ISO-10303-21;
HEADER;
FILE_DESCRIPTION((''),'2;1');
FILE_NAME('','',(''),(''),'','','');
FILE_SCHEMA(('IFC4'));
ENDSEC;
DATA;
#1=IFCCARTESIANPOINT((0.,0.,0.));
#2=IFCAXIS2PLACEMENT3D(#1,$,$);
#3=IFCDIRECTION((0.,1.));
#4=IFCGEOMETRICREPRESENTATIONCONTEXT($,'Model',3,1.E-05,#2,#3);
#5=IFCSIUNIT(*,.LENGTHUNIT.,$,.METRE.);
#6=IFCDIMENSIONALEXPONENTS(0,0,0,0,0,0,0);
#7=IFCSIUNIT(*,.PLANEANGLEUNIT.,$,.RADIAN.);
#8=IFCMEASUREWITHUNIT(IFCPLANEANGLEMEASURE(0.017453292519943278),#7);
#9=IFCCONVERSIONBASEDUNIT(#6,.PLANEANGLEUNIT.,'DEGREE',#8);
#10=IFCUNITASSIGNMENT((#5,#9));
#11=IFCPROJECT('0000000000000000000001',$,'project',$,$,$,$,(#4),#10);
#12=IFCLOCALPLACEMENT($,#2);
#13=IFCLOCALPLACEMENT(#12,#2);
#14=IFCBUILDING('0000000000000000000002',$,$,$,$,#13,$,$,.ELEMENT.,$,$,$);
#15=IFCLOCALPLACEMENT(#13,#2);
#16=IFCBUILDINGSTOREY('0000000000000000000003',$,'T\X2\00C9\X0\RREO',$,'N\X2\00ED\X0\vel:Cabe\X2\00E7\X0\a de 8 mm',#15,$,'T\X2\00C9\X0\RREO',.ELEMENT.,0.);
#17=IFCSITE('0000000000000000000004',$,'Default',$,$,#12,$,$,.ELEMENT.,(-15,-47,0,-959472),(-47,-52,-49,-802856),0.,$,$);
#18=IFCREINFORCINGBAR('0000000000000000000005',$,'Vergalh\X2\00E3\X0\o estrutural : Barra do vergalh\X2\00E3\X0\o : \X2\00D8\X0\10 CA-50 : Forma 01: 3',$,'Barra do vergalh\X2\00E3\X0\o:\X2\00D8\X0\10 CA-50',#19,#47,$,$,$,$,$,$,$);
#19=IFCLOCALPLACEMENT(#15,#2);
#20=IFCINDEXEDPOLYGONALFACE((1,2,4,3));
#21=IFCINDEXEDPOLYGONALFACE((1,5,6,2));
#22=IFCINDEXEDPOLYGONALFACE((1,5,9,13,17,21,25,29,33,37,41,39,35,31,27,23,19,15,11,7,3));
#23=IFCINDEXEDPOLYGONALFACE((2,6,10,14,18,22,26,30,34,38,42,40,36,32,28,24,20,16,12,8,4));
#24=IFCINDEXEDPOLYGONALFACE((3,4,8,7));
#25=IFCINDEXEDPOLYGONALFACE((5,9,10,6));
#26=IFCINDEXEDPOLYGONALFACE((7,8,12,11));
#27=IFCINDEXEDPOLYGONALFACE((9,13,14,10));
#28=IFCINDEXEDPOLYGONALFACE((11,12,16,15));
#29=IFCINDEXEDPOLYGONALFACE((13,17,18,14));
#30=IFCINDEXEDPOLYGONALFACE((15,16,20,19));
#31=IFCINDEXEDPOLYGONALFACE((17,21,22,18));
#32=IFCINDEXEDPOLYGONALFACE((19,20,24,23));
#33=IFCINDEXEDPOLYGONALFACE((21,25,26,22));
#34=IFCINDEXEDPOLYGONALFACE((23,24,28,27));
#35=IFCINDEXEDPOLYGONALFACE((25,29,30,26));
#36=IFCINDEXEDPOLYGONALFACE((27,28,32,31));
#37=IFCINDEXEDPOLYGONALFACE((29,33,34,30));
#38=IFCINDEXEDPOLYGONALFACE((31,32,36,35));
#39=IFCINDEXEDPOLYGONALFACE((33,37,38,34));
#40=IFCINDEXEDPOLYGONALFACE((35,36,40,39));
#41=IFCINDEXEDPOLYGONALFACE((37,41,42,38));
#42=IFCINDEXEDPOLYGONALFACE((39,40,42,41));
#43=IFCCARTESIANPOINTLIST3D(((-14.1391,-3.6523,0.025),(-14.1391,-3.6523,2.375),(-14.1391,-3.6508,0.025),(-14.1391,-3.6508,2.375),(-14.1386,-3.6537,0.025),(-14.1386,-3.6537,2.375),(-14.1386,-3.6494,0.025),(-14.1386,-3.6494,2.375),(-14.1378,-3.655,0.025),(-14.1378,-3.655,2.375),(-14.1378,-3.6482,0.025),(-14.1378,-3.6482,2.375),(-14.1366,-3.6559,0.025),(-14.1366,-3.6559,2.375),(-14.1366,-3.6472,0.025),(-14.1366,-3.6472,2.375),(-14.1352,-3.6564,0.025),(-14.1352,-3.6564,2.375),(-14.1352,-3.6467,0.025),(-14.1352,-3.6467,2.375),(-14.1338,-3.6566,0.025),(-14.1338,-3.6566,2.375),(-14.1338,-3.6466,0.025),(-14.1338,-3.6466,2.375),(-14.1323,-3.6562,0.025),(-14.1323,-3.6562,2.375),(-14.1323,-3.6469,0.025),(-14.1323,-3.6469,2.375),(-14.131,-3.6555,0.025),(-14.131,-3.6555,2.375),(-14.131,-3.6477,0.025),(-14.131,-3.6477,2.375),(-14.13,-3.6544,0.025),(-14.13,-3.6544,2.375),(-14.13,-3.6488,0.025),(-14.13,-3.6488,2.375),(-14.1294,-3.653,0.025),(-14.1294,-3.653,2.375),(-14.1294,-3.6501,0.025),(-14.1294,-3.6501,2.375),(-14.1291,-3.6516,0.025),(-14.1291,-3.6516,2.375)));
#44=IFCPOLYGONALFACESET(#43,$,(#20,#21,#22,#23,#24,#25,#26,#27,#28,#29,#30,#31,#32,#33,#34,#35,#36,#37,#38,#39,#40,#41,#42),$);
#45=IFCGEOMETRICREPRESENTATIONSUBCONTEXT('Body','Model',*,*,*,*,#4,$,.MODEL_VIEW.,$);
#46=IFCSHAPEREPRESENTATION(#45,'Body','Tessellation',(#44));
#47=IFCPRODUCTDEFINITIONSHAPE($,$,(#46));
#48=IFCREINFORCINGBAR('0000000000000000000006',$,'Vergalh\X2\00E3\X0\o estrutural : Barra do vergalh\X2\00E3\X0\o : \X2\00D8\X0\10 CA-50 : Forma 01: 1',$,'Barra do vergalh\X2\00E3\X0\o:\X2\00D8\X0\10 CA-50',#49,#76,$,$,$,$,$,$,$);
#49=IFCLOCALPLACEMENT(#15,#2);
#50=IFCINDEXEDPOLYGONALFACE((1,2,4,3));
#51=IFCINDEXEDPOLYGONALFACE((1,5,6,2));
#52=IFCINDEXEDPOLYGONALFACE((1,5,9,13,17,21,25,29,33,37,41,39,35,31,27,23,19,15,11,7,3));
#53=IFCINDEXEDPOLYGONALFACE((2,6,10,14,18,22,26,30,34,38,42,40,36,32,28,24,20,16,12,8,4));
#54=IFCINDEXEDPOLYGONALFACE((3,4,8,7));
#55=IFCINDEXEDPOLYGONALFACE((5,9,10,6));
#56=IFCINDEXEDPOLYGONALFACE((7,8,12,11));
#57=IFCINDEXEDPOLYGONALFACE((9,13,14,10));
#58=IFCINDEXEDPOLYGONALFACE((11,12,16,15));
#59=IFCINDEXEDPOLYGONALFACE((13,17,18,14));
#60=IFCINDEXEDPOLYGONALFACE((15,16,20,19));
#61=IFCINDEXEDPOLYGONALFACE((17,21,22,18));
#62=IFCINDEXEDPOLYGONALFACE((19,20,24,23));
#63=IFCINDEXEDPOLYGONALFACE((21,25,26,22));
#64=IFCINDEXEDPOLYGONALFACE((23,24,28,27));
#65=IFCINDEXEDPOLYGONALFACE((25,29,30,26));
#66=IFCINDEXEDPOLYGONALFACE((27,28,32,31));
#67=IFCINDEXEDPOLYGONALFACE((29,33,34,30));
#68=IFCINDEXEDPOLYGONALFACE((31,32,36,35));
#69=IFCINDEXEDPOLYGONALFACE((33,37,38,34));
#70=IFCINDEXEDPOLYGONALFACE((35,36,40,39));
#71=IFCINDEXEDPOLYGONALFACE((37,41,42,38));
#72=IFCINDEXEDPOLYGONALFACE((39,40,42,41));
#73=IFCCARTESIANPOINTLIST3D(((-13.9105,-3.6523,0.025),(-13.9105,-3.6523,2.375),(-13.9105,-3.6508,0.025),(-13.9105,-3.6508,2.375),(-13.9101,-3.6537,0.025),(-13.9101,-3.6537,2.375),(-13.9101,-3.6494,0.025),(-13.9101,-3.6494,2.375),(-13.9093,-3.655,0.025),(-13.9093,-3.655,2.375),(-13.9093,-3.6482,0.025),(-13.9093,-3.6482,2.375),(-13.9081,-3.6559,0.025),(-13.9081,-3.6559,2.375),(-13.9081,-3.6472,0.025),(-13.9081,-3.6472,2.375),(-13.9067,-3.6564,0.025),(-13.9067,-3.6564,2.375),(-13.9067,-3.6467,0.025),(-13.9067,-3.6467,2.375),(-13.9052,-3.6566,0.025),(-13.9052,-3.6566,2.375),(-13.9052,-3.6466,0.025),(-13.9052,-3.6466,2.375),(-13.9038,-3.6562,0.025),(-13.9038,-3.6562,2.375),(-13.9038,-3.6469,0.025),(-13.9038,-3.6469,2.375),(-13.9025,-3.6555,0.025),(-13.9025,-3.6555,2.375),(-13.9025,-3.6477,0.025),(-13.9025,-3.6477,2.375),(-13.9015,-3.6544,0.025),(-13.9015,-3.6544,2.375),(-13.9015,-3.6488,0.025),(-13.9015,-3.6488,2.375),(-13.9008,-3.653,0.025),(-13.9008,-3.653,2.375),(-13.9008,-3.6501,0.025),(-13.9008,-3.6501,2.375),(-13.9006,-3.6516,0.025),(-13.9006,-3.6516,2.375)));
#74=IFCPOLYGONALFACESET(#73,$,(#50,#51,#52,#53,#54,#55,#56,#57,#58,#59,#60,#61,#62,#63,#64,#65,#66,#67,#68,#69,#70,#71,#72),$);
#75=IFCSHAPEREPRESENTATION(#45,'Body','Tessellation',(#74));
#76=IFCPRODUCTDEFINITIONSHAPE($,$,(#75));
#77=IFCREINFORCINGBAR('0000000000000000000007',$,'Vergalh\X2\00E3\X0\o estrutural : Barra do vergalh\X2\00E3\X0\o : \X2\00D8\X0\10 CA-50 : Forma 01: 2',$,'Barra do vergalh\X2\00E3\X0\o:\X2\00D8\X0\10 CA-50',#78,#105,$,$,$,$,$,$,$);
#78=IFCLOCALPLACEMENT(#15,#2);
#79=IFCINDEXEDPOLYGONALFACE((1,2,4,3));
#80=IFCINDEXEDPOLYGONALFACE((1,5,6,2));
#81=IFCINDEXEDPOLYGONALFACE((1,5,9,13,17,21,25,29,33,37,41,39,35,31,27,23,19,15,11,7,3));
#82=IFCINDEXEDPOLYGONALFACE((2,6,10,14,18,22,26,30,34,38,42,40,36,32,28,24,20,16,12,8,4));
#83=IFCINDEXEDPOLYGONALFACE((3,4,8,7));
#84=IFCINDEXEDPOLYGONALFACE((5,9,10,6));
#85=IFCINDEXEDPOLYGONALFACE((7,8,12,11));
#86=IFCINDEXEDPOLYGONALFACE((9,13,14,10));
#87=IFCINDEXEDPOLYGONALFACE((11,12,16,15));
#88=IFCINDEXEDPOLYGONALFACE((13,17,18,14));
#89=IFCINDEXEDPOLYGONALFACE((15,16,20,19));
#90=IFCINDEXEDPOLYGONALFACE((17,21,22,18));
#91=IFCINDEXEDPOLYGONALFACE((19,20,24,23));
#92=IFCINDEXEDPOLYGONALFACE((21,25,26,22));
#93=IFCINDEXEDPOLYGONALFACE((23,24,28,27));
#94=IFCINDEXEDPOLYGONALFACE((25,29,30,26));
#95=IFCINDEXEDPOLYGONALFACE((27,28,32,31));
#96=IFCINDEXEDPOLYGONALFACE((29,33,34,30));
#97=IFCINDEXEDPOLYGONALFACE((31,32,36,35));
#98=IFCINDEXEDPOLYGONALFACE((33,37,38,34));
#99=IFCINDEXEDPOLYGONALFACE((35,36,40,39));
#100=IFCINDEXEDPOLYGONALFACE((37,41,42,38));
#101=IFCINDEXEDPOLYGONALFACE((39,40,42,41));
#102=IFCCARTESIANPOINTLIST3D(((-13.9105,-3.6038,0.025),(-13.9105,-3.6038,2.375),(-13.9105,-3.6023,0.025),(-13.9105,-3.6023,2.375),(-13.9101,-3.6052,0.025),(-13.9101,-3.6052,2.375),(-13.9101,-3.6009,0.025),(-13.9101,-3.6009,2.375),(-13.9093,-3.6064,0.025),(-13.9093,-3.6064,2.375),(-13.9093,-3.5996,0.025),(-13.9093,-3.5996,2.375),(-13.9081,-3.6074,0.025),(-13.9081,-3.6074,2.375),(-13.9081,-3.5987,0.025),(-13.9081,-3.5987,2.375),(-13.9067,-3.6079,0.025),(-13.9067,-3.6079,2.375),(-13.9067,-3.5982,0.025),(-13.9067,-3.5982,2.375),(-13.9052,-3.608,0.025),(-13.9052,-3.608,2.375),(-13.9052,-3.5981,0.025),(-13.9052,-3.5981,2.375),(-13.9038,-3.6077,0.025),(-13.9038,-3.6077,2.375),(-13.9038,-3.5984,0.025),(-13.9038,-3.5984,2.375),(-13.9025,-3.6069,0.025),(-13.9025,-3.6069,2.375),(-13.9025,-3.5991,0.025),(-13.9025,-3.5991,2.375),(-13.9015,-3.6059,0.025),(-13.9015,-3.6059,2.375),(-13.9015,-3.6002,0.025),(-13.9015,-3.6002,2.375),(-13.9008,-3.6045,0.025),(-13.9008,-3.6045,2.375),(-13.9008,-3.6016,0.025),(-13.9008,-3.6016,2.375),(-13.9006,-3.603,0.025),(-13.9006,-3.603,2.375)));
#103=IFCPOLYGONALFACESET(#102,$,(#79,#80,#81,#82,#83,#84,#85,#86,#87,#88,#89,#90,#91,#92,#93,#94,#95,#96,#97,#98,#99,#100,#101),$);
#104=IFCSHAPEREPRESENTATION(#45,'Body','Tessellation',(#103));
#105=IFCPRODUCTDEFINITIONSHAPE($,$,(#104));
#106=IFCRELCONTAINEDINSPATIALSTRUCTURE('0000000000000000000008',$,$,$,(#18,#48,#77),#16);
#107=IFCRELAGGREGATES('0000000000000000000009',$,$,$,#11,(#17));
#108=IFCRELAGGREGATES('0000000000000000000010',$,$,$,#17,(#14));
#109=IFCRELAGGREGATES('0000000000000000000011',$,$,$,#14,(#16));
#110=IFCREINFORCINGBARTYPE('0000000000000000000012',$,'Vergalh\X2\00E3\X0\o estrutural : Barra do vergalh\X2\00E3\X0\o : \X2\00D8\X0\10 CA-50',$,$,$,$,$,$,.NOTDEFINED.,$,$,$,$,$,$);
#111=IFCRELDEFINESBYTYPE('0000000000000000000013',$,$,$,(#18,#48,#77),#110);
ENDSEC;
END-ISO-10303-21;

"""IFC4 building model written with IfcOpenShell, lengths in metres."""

from ifc_helpers import new_model, entity, si_unit, converted_unit, direction, origin, place, context, subcontext, project, spatial, type_object, element, save


model = new_model("IFC4")

# Units and contexts
model_context = context("Model", 3, precision=1e-05, world=origin(), true_north=direction((0.0, 1.0)))
body_context = subcontext(model_context, "Body", "Model", "MODEL_VIEW")
ifc_project = project(units=[si_unit("LENGTHUNIT", "METRE"), converted_unit("PLANEANGLEUNIT", "DEGREE", entity("IfcPlaneAngleMeasure", 0.017453292519943278), si_unit("PLANEANGLEUNIT", "RADIAN"), dimensions=[0, 0, 0, 0, 0, 0, 0])], contexts=[model_context])

# Site, building, storey
site_placement = place(None, origin())
site = spatial("IfcSite", under=ifc_project, at=site_placement, Name="Default", CompositionType="ELEMENT", RefLatitude=(-15, -47, 0, -959472), RefLongitude=(-47, -52, -49, -802856), RefElevation=0.0)
building_placement = place(site_placement, origin())
building = spatial("IfcBuilding", under=site, at=building_placement, CompositionType="ELEMENT")
storey_placement = place(building_placement, origin())
storey = spatial("IfcBuildingStorey", under=building, at=storey_placement, Name="TÉRREO", ObjectType="Nível:Cabeça de 8 mm", LongName="TÉRREO", CompositionType="ELEMENT", Elevation=0.0)

# Reinforcing bars
reinforcing_bar_type_1 = type_object("IfcReinforcingBarType", Name="Vergalhão estrutural : Barra do vergalhão : Ø10 CA-50", PredefinedType="NOTDEFINED")
reinforcing_bar_1_placement = place(storey_placement, origin())
element("IfcReinforcingBar", 1, at=reinforcing_bar_1_placement, inside=storey, type_object=reinforcing_bar_type_1, Name="Vergalhão estrutural : Barra do vergalhão : Ø10 CA-50 : Forma 01: 3", ObjectType="Barra do vergalhão:Ø10 CA-50", context=body_context, shape_type="AdvancedSweptSolid", body=[
    entity("IfcSweptDiskSolid", entity("IfcIndexedPolyCurve", entity("IfcCartesianPointList3D", [[-14.1341, -3.6516, 0.025], [-14.1341, -3.6516, 2.375]]), None, False), 0.005, None, 0.0, 1.0),
])
reinforcing_bar_2_placement = place(storey_placement, origin())
element("IfcReinforcingBar", 2, at=reinforcing_bar_2_placement, inside=storey, type_object=reinforcing_bar_type_1, Name="Vergalhão estrutural : Barra do vergalhão : Ø10 CA-50 : Forma 01: 1", ObjectType="Barra do vergalhão:Ø10 CA-50", context=body_context, shape_type="AdvancedSweptSolid", body=[
    entity("IfcSweptDiskSolid", entity("IfcIndexedPolyCurve", entity("IfcCartesianPointList3D", [[-13.9056, -3.6516, 0.025], [-13.9056, -3.6516, 2.375]]), None, False), 0.005, None, 0.0, 1.0),
])
reinforcing_bar_3_placement = place(storey_placement, origin())
element("IfcReinforcingBar", 3, at=reinforcing_bar_3_placement, inside=storey, type_object=reinforcing_bar_type_1, Name="Vergalhão estrutural : Barra do vergalhão : Ø10 CA-50 : Forma 01: 2", ObjectType="Barra do vergalhão:Ø10 CA-50", context=body_context, shape_type="AdvancedSweptSolid", body=[
    entity("IfcSweptDiskSolid", entity("IfcIndexedPolyCurve", entity("IfcCartesianPointList3D", [[-13.9056, -3.603, 0.025], [-13.9056, -3.603, 2.375]]), None, False), 0.005, None, 0.0, 1.0),
])

save(model, "model.ifc")
